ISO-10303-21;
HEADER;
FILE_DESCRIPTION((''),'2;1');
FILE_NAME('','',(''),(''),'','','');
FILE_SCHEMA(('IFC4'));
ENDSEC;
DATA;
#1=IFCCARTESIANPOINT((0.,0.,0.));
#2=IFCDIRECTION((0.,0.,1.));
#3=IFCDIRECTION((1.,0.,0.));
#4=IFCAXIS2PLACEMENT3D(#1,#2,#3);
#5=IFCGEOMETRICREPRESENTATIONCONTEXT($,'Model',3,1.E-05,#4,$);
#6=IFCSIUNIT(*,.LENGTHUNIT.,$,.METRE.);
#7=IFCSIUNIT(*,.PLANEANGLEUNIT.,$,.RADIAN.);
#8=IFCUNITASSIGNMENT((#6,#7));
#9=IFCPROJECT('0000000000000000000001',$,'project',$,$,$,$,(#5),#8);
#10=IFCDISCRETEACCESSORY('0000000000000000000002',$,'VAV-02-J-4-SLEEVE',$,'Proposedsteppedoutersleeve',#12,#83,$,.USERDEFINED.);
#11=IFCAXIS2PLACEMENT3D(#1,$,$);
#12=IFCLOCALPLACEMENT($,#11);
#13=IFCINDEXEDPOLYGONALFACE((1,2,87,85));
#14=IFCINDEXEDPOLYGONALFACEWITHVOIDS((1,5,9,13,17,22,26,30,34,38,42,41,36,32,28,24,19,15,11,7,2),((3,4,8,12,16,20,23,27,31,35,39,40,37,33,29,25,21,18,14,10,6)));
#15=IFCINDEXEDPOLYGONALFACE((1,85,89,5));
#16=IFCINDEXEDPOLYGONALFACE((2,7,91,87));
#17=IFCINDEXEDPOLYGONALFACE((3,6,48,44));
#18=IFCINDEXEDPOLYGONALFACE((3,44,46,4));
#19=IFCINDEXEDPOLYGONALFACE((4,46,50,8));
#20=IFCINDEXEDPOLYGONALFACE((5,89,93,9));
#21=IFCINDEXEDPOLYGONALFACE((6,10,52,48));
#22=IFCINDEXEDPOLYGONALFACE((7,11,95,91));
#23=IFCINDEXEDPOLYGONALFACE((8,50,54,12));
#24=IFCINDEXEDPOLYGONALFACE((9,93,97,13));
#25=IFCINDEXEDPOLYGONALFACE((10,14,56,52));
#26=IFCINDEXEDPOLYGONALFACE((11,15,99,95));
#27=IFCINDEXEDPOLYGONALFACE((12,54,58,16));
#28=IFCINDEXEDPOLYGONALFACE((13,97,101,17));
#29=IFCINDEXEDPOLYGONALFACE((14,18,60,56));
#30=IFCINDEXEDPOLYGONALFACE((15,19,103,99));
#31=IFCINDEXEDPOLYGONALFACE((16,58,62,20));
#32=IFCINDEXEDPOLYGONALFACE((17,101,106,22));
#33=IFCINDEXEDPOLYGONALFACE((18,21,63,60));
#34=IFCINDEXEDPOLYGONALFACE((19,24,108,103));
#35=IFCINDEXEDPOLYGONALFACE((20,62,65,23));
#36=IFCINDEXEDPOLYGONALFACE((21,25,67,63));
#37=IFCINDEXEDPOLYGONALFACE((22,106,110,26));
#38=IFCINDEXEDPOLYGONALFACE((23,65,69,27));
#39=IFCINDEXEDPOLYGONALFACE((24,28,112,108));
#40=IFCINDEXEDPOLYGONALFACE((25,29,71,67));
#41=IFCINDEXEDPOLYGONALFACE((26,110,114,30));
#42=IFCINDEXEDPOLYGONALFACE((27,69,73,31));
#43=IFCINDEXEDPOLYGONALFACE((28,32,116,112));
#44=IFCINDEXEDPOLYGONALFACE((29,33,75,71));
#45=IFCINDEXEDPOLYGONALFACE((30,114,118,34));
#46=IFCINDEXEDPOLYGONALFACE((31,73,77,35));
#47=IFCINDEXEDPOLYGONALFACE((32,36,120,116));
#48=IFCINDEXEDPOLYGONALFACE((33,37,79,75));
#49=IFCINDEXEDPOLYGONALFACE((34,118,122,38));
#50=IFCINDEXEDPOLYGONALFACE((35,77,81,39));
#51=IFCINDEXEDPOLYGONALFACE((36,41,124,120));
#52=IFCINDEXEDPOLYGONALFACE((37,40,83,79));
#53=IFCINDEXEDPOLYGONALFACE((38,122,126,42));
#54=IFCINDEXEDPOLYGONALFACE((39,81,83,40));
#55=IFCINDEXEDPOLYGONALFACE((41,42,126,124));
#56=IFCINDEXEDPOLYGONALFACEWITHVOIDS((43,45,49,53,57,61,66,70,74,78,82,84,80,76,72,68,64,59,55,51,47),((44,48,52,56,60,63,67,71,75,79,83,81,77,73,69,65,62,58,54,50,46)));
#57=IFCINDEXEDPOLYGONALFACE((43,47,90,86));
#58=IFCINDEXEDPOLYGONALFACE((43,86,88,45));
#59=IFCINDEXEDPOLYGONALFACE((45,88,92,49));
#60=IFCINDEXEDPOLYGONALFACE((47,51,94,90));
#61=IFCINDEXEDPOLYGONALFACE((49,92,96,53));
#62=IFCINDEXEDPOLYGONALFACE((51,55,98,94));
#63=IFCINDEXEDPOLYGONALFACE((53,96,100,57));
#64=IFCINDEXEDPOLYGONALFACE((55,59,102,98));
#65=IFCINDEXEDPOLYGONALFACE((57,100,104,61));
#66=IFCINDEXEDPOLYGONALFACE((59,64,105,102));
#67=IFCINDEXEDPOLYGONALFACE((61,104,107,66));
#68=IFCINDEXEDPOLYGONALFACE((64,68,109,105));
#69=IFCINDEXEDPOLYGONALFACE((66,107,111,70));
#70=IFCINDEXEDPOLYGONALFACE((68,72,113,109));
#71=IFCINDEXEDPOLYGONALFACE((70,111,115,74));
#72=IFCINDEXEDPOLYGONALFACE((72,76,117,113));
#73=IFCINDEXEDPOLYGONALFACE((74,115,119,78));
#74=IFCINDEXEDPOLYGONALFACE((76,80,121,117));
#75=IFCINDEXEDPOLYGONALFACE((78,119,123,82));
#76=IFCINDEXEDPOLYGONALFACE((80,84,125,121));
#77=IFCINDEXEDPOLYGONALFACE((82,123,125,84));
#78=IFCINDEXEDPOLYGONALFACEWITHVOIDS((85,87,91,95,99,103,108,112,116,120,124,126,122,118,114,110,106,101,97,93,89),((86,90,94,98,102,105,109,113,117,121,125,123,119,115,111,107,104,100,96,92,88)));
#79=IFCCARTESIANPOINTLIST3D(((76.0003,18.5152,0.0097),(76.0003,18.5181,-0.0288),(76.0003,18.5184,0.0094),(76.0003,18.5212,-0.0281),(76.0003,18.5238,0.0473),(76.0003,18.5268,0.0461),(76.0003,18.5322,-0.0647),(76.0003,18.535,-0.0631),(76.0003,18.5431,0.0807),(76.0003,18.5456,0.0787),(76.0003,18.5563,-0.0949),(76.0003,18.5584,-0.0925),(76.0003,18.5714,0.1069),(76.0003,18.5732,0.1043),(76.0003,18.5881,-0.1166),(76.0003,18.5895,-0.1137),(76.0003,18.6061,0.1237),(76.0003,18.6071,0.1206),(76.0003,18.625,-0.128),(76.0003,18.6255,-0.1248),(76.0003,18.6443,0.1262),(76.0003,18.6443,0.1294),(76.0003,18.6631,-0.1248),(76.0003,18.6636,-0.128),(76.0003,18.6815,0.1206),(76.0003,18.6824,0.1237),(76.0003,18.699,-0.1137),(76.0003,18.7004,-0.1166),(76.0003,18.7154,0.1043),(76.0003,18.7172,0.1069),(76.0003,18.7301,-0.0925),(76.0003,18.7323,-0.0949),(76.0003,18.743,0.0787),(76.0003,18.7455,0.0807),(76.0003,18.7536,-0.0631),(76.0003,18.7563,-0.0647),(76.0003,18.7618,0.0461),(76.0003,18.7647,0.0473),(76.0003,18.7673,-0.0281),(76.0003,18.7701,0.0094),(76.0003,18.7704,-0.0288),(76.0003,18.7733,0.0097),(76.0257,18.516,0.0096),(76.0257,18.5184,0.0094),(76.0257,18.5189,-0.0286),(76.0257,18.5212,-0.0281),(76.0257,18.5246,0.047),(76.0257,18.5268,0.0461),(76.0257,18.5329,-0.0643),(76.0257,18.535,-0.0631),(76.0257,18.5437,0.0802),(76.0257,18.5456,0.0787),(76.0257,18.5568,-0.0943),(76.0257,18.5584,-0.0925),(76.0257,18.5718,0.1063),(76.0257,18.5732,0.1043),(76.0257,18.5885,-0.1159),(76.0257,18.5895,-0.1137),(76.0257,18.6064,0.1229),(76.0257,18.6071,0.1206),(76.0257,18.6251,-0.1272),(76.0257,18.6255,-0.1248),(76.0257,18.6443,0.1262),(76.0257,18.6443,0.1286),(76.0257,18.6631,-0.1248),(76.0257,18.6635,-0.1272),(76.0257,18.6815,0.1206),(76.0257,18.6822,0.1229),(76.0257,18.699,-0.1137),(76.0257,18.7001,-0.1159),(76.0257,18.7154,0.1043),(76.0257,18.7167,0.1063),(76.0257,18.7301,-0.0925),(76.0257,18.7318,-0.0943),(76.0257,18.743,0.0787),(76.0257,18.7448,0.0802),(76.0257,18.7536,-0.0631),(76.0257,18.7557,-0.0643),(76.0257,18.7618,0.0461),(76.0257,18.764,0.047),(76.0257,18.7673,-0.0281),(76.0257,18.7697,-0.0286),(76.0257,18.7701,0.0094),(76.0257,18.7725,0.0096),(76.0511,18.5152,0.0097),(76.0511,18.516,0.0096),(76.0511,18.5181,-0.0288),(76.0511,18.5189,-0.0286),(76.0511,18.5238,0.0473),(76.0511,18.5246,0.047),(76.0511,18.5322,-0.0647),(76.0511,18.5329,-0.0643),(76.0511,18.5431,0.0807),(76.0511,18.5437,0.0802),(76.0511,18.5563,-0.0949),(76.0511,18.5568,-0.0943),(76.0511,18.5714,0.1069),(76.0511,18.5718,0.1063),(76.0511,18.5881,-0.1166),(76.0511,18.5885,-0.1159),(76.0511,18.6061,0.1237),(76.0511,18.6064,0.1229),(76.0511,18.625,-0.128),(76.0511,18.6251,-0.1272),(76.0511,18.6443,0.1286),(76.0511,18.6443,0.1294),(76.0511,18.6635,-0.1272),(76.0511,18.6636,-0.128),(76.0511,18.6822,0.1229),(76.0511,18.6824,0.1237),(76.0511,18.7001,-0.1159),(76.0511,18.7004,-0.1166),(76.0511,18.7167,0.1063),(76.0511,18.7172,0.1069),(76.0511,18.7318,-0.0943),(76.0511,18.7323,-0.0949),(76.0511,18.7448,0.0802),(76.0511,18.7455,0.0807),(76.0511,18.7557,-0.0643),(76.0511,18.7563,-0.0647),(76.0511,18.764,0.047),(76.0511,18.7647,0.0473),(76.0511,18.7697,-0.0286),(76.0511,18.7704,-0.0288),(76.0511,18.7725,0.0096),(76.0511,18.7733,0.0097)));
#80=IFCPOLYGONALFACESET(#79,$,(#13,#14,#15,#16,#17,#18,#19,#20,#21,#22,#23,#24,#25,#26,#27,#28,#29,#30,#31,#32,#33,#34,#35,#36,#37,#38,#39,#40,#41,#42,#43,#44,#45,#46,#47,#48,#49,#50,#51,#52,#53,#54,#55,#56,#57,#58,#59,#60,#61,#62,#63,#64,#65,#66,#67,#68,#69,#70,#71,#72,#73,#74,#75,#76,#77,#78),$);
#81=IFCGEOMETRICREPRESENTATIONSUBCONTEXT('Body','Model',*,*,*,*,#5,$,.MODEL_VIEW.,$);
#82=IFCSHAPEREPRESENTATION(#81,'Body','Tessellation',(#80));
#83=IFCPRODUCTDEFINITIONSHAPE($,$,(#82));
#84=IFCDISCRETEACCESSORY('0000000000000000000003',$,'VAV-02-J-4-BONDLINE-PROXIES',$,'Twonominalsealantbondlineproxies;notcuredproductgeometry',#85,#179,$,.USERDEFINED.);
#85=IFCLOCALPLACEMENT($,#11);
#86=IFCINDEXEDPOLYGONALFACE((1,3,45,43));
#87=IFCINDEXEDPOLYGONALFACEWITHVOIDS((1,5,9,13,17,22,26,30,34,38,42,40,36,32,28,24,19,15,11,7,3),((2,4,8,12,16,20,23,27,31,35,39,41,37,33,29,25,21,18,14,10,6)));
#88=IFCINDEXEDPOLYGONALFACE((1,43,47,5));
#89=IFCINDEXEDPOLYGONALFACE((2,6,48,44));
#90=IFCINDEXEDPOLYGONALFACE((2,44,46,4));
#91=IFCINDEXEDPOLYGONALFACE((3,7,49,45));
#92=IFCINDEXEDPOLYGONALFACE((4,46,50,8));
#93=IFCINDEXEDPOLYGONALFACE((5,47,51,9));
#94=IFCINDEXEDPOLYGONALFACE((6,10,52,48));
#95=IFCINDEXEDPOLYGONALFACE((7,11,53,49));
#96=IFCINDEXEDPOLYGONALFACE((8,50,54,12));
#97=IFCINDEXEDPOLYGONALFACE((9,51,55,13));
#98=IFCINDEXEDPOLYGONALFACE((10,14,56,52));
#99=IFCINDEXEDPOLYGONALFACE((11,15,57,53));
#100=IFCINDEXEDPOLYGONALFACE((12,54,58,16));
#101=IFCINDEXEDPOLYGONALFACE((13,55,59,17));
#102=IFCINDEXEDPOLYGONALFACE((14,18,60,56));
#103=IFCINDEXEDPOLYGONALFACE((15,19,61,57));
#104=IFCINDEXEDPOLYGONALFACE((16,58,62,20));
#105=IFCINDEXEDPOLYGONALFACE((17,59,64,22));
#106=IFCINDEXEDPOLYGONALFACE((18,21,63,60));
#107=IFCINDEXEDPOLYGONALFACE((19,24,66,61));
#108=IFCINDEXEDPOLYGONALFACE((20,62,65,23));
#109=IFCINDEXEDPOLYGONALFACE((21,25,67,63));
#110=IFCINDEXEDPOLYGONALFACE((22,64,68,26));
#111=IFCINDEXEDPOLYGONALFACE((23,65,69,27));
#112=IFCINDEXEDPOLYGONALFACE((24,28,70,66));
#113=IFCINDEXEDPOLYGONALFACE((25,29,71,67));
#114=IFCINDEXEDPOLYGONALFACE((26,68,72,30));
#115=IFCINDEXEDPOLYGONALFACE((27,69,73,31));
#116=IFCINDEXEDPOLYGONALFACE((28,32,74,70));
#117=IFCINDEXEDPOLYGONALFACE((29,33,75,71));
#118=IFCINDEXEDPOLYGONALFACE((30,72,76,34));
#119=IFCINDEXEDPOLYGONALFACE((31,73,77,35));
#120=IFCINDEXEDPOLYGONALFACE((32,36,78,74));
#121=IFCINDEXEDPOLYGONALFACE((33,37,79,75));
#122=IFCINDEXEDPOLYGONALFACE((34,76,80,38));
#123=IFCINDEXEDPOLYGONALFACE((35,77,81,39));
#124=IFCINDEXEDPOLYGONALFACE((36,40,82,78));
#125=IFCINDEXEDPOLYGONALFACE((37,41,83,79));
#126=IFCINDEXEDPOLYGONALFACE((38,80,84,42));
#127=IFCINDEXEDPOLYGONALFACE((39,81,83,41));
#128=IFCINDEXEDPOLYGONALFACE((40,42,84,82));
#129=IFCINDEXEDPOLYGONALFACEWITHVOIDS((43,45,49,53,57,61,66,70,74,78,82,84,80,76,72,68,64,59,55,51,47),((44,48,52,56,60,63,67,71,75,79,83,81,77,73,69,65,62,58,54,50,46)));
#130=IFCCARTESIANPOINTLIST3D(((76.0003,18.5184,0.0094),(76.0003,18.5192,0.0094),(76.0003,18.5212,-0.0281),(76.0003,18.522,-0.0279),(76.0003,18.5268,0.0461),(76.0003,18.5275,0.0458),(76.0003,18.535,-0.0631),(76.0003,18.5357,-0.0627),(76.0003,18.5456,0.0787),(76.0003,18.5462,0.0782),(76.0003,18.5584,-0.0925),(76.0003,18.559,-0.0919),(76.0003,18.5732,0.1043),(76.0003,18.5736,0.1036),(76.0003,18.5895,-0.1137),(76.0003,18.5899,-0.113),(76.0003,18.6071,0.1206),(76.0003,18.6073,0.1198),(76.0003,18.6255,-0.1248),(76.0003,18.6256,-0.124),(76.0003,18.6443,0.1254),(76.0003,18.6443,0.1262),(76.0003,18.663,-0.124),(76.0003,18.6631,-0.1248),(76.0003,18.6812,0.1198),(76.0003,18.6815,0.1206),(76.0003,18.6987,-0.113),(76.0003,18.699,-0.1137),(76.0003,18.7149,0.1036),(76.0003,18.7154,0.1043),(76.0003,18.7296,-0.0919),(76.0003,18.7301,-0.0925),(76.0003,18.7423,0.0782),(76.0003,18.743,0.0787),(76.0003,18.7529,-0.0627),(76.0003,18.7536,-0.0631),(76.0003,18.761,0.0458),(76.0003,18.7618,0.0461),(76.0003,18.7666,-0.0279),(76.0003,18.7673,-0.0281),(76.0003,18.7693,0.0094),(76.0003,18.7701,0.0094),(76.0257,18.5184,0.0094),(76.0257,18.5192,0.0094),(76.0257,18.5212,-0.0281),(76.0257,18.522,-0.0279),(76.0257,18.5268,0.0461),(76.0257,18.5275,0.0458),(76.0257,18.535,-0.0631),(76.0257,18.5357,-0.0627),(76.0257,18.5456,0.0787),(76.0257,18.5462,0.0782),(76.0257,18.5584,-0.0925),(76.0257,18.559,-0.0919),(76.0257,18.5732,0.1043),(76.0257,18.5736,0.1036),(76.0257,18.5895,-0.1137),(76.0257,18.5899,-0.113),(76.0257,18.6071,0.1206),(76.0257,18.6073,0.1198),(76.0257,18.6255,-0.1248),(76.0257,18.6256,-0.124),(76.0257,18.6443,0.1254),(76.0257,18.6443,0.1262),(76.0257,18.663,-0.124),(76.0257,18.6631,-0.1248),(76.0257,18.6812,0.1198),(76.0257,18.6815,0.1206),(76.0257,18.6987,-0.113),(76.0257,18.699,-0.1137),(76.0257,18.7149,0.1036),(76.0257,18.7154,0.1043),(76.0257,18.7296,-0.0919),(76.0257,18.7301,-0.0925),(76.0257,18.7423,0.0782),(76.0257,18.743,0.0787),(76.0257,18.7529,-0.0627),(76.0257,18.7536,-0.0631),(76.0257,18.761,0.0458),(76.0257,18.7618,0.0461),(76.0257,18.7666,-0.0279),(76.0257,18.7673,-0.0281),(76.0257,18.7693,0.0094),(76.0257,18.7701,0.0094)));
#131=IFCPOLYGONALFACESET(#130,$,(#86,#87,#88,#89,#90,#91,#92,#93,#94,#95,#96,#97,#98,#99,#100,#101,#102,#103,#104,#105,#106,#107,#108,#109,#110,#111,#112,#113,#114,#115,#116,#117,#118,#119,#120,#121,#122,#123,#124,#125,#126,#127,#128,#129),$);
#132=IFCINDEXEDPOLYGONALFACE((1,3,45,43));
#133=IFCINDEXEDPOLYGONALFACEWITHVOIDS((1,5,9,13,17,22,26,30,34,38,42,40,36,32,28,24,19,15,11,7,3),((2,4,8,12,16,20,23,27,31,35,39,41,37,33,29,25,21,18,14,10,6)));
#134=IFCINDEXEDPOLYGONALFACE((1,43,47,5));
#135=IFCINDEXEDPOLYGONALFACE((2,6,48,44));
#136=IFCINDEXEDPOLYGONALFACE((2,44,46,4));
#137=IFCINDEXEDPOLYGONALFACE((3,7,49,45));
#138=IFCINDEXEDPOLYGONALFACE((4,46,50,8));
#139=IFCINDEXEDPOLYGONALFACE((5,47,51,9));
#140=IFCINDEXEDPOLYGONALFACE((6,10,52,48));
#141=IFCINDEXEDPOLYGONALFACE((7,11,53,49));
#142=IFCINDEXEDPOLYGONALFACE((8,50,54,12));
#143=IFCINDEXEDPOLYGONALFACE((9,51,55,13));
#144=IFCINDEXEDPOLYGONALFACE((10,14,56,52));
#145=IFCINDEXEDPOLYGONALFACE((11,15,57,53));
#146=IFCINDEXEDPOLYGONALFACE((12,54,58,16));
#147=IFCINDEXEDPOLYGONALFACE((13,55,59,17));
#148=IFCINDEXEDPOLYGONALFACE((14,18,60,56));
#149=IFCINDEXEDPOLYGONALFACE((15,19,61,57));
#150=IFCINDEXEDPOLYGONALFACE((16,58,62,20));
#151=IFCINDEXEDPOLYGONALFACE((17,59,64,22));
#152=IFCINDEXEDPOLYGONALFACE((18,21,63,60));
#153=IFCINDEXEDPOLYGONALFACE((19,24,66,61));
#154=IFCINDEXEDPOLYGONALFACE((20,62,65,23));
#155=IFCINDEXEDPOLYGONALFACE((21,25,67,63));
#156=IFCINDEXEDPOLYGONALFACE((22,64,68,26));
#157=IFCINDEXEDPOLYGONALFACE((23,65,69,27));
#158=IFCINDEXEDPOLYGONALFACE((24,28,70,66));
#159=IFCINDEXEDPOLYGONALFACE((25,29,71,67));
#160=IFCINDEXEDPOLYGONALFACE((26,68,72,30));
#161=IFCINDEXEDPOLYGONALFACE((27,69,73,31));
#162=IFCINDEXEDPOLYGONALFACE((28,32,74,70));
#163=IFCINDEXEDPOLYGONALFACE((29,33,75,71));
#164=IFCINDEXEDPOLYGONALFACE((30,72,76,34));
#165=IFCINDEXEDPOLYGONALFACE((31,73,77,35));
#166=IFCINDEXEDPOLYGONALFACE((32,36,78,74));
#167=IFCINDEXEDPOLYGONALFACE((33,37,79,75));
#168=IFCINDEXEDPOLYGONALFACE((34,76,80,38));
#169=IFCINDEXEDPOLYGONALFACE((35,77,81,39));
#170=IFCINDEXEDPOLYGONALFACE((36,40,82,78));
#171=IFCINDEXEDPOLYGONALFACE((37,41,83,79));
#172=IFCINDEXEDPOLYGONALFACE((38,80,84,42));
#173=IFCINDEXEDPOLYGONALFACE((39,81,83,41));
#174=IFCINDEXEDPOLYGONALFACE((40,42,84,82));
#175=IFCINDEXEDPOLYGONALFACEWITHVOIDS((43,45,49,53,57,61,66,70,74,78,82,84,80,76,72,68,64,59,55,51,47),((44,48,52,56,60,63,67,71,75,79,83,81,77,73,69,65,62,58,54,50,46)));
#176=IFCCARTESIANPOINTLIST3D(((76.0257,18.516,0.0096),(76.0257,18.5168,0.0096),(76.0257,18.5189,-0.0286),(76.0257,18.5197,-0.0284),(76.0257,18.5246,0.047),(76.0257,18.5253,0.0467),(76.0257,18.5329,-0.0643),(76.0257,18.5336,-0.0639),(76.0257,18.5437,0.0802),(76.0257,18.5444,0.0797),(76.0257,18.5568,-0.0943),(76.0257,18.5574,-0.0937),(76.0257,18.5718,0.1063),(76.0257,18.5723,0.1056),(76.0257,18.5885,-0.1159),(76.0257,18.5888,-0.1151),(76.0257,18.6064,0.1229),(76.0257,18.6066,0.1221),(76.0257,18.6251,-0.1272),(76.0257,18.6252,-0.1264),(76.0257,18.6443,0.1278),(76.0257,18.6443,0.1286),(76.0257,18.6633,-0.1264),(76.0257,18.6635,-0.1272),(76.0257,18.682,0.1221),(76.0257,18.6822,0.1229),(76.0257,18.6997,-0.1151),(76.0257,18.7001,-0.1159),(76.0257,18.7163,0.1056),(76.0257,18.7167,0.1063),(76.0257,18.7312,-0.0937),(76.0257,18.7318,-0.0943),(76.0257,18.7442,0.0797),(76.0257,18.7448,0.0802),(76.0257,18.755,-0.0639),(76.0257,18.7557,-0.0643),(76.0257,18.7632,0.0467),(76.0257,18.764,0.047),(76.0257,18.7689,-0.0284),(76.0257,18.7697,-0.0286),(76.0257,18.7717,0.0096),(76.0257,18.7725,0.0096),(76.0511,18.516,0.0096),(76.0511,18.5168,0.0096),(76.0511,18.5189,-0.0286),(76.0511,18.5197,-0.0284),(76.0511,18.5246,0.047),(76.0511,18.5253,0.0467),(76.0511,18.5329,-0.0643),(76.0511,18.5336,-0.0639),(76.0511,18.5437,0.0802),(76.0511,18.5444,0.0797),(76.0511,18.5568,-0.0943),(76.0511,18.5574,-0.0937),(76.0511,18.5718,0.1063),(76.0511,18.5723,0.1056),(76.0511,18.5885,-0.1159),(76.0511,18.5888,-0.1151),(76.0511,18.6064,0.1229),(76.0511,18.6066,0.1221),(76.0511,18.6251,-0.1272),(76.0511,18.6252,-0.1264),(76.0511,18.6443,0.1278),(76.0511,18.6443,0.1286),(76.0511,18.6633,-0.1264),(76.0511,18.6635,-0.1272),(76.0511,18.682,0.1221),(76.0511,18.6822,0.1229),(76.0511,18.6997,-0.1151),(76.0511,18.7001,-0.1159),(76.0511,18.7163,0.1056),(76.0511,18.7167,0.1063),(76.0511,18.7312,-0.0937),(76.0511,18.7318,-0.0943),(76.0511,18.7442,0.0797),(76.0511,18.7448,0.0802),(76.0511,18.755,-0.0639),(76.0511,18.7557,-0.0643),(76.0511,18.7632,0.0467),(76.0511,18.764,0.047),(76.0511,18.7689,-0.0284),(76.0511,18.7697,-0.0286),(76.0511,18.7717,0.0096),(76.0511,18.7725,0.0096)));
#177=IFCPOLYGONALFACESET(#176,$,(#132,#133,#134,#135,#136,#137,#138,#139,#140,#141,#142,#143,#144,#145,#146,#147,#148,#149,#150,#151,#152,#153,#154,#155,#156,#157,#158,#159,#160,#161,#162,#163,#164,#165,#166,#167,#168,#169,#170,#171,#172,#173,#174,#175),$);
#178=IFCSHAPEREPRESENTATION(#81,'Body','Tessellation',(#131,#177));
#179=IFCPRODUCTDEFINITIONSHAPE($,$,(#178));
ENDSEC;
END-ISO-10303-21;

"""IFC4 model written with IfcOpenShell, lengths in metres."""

from ifc_helpers import new_model, entity, si_unit, frame, origin_with_axes, place, context, subcontext, project, element, save


model = new_model("IFC4")

# Units and contexts
model_context = context("Model", 3, precision=1e-05, world=origin_with_axes())
body_context = subcontext(model_context, "Body", "Model", "MODEL_VIEW")
ifc_project = project(units=[si_unit("LENGTHUNIT", "METRE"), si_unit("PLANEANGLEUNIT", "RADIAN")], contexts=[model_context])

# Discrete accessories
discrete_accessory_1_placement = place(None, frame((76.0257, 18.6443, 0.0), z_axis=(0.0, 1.0, 0.0), x_axis=(0.0, 0.0, 1.0)))
element("IfcDiscreteAccessory", 1, at=discrete_accessory_1_placement, Name="VAV-02-J-4-SLEEVE", ObjectType="Proposedsteppedoutersleeve", PredefinedType="USERDEFINED", context=body_context, shape_type="SweptSolid", body=[
    entity("IfcRevolvedAreaSolid", entity("IfcArbitraryClosedProfileDef", "AREA", None, entity("IfcPolyline", [entity("IfcCartesianPoint", [0.1262, -0.0254]), entity("IfcCartesianPoint", [0.1294, -0.0254]), entity("IfcCartesianPoint", [0.1294, 0.0254]), entity("IfcCartesianPoint", [0.1286, 0.0254]), entity("IfcCartesianPoint", [0.1286, 0.0]), entity("IfcCartesianPoint", [0.1262, 0.0]), entity("IfcCartesianPoint", [0.1262, -0.0254])])), entity("IfcAxis2Placement3D", entity("IfcCartesianPoint", [0.0, 0.0, 0.0])), entity("IfcAxis1Placement", entity("IfcCartesianPoint", [0.0, 0.0, 0.0]), entity("IfcDirection", [0.0, 1.0, 0.0])), 6.283185),
])
discrete_accessory_2_placement = place(None, frame((76.0257, 18.6443, 0.0), z_axis=(0.0, 1.0, 0.0), x_axis=(0.0, 0.0, 1.0)))
element("IfcDiscreteAccessory", 2, at=discrete_accessory_2_placement, Name="VAV-02-J-4-BONDLINE-PROXIES", ObjectType="Twonominalsealantbondlineproxies;notcuredproductgeometry", PredefinedType="USERDEFINED", context=body_context, shape_type="SweptSolid", body=[
    entity("IfcRevolvedAreaSolid", entity("IfcArbitraryClosedProfileDef", "AREA", None, entity("IfcPolyline", [entity("IfcCartesianPoint", [0.1254, -0.0254]), entity("IfcCartesianPoint", [0.1262, -0.0254]), entity("IfcCartesianPoint", [0.1262, 0.0]), entity("IfcCartesianPoint", [0.1254, 0.0]), entity("IfcCartesianPoint", [0.1254, -0.0254])])), entity("IfcAxis2Placement3D", entity("IfcCartesianPoint", [0.0, 0.0, 0.0])), entity("IfcAxis1Placement", entity("IfcCartesianPoint", [0.0, 0.0, 0.0]), entity("IfcDirection", [0.0, 1.0, 0.0])), 6.283185),
    entity("IfcRevolvedAreaSolid", entity("IfcArbitraryClosedProfileDef", "AREA", None, entity("IfcPolyline", [entity("IfcCartesianPoint", [0.1278, 0.0]), entity("IfcCartesianPoint", [0.1286, 0.0]), entity("IfcCartesianPoint", [0.1286, 0.0254]), entity("IfcCartesianPoint", [0.1278, 0.0254]), entity("IfcCartesianPoint", [0.1278, 0.0])])), entity("IfcAxis2Placement3D", entity("IfcCartesianPoint", [0.0, 0.0, 0.0])), entity("IfcAxis1Placement", entity("IfcCartesianPoint", [0.0, 0.0, 0.0]), entity("IfcDirection", [0.0, 1.0, 0.0])), 6.283185),
])

save(model, "model.ifc")
